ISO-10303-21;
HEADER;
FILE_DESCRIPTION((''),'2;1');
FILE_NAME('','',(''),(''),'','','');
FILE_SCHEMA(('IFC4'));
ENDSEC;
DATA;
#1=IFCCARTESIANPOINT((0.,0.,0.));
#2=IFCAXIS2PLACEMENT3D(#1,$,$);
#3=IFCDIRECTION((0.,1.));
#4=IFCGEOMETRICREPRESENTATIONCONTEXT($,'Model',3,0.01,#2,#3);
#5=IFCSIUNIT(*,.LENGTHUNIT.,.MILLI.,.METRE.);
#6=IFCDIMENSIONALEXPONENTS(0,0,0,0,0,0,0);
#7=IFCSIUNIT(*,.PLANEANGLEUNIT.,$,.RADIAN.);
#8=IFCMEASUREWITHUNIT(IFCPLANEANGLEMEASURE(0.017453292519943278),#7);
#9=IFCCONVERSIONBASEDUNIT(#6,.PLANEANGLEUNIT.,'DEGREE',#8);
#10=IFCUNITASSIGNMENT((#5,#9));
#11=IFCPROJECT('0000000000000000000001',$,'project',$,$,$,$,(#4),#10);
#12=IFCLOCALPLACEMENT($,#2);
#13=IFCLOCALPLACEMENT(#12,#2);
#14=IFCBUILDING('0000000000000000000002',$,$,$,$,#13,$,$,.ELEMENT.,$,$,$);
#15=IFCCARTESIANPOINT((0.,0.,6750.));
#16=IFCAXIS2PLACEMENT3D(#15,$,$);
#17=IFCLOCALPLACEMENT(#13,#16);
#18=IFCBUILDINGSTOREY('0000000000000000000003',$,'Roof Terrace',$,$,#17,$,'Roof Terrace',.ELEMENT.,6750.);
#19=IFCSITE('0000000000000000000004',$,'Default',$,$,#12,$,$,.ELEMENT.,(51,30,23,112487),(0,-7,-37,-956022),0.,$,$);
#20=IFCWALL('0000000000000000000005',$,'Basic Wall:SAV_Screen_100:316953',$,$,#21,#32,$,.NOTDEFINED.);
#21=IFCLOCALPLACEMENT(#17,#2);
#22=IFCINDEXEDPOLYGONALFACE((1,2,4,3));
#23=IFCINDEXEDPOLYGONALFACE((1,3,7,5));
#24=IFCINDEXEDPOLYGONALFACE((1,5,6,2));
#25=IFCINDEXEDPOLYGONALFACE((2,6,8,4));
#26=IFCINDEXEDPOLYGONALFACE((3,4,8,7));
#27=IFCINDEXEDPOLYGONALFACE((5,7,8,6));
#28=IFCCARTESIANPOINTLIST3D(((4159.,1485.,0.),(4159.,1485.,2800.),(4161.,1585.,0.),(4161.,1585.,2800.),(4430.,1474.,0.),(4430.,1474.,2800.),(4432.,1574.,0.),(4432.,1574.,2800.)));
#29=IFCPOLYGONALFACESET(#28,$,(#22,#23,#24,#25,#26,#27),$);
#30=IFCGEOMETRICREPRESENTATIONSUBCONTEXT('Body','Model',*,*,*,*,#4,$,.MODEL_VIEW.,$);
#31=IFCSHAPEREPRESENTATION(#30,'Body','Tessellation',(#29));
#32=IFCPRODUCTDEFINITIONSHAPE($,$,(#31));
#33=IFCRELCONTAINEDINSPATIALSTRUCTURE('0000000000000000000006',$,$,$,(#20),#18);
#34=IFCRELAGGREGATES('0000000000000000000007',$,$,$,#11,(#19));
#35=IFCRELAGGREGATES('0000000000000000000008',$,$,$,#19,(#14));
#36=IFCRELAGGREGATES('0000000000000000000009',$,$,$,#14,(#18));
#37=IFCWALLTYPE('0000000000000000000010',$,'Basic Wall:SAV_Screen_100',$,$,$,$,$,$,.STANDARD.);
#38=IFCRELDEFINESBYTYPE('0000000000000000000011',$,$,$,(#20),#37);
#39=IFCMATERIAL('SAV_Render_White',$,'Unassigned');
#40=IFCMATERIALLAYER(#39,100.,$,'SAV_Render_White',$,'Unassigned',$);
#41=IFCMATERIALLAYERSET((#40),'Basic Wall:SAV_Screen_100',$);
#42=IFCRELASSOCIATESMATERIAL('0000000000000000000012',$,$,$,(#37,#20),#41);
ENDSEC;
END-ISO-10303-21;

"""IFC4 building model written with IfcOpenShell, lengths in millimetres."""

from ifc_helpers import new_model, entity, si_unit, converted_unit, direction, frame, origin, place, context, subcontext, project, spatial, polyline, outline, extrude, material, layer, layer_set, layer_usage, type_object, element, save


model = new_model("IFC4")

# Units and contexts
model_context = context("Model", 3, precision=0.01, world=origin(), true_north=direction((0.0, 1.0)))
body_context = subcontext(model_context, "Body", "Model", "MODEL_VIEW")
ifc_project = project(units=[si_unit("LENGTHUNIT", "METRE", prefix="MILLI"), converted_unit("PLANEANGLEUNIT", "DEGREE", entity("IfcPlaneAngleMeasure", 0.017453292519943278), si_unit("PLANEANGLEUNIT", "RADIAN"), dimensions=[0, 0, 0, 0, 0, 0, 0])], contexts=[model_context])

# Site, building, storey
site_placement = place(None, origin())
site = spatial("IfcSite", under=ifc_project, at=site_placement, Name="Default", CompositionType="ELEMENT", RefLatitude=(51, 30, 23, 112487), RefLongitude=(0, -7, -37, -956022), RefElevation=0.0)
building_placement = place(site_placement, origin())
building = spatial("IfcBuilding", under=site, at=building_placement, CompositionType="ELEMENT")
storey_placement = place(building_placement, frame((0.0, 0.0, 6750.0)))
storey = spatial("IfcBuildingStorey", under=building, at=storey_placement, Name="Roof Terrace", LongName="Roof Terrace", CompositionType="ELEMENT", Elevation=6750.0)

# Wall
ifc_material_1 = material(Name="SAV_Render_White", Category="Unassigned")
ifc_layer_1 = layer(ifc_material_1, 100.0, Name="SAV_Render_White", Category="Unassigned")
ifc_layer_set_1 = layer_set([ifc_layer_1], Name="Basic Wall:SAV_Screen_100")
wall_type_1 = type_object("IfcWallType", Name="Basic Wall:SAV_Screen_100", PredefinedType="STANDARD", material=ifc_layer_set_1)
ifc_layer_usage_1 = layer_usage(ifc_layer_set_1, "AXIS2", "NEGATIVE", 50.0)
wall_1_placement = place(storey_placement, frame((4159.0, 1535.0, 0.0), z_axis=(0.0, 0.0, 1.0), x_axis=(0.999177, -0.040557, 0.0)))
element("IfcWall", 1, at=wall_1_placement, inside=storey, type_object=wall_type_1, material=ifc_layer_usage_1, Name="Basic Wall:SAV_Screen_100:316953", PredefinedType="NOTDEFINED", context=body_context, shape_type="SweptSolid", body=[
    extrude(outline(polyline([(273.3, -50.0), (271.2, 50.0), (0.0, 50.0), (2.0, -50.0), (273.3, -50.0)])), origin(), (0.0, 0.0, 1.0), 2800.0),
])

save(model, "model.ifc")
